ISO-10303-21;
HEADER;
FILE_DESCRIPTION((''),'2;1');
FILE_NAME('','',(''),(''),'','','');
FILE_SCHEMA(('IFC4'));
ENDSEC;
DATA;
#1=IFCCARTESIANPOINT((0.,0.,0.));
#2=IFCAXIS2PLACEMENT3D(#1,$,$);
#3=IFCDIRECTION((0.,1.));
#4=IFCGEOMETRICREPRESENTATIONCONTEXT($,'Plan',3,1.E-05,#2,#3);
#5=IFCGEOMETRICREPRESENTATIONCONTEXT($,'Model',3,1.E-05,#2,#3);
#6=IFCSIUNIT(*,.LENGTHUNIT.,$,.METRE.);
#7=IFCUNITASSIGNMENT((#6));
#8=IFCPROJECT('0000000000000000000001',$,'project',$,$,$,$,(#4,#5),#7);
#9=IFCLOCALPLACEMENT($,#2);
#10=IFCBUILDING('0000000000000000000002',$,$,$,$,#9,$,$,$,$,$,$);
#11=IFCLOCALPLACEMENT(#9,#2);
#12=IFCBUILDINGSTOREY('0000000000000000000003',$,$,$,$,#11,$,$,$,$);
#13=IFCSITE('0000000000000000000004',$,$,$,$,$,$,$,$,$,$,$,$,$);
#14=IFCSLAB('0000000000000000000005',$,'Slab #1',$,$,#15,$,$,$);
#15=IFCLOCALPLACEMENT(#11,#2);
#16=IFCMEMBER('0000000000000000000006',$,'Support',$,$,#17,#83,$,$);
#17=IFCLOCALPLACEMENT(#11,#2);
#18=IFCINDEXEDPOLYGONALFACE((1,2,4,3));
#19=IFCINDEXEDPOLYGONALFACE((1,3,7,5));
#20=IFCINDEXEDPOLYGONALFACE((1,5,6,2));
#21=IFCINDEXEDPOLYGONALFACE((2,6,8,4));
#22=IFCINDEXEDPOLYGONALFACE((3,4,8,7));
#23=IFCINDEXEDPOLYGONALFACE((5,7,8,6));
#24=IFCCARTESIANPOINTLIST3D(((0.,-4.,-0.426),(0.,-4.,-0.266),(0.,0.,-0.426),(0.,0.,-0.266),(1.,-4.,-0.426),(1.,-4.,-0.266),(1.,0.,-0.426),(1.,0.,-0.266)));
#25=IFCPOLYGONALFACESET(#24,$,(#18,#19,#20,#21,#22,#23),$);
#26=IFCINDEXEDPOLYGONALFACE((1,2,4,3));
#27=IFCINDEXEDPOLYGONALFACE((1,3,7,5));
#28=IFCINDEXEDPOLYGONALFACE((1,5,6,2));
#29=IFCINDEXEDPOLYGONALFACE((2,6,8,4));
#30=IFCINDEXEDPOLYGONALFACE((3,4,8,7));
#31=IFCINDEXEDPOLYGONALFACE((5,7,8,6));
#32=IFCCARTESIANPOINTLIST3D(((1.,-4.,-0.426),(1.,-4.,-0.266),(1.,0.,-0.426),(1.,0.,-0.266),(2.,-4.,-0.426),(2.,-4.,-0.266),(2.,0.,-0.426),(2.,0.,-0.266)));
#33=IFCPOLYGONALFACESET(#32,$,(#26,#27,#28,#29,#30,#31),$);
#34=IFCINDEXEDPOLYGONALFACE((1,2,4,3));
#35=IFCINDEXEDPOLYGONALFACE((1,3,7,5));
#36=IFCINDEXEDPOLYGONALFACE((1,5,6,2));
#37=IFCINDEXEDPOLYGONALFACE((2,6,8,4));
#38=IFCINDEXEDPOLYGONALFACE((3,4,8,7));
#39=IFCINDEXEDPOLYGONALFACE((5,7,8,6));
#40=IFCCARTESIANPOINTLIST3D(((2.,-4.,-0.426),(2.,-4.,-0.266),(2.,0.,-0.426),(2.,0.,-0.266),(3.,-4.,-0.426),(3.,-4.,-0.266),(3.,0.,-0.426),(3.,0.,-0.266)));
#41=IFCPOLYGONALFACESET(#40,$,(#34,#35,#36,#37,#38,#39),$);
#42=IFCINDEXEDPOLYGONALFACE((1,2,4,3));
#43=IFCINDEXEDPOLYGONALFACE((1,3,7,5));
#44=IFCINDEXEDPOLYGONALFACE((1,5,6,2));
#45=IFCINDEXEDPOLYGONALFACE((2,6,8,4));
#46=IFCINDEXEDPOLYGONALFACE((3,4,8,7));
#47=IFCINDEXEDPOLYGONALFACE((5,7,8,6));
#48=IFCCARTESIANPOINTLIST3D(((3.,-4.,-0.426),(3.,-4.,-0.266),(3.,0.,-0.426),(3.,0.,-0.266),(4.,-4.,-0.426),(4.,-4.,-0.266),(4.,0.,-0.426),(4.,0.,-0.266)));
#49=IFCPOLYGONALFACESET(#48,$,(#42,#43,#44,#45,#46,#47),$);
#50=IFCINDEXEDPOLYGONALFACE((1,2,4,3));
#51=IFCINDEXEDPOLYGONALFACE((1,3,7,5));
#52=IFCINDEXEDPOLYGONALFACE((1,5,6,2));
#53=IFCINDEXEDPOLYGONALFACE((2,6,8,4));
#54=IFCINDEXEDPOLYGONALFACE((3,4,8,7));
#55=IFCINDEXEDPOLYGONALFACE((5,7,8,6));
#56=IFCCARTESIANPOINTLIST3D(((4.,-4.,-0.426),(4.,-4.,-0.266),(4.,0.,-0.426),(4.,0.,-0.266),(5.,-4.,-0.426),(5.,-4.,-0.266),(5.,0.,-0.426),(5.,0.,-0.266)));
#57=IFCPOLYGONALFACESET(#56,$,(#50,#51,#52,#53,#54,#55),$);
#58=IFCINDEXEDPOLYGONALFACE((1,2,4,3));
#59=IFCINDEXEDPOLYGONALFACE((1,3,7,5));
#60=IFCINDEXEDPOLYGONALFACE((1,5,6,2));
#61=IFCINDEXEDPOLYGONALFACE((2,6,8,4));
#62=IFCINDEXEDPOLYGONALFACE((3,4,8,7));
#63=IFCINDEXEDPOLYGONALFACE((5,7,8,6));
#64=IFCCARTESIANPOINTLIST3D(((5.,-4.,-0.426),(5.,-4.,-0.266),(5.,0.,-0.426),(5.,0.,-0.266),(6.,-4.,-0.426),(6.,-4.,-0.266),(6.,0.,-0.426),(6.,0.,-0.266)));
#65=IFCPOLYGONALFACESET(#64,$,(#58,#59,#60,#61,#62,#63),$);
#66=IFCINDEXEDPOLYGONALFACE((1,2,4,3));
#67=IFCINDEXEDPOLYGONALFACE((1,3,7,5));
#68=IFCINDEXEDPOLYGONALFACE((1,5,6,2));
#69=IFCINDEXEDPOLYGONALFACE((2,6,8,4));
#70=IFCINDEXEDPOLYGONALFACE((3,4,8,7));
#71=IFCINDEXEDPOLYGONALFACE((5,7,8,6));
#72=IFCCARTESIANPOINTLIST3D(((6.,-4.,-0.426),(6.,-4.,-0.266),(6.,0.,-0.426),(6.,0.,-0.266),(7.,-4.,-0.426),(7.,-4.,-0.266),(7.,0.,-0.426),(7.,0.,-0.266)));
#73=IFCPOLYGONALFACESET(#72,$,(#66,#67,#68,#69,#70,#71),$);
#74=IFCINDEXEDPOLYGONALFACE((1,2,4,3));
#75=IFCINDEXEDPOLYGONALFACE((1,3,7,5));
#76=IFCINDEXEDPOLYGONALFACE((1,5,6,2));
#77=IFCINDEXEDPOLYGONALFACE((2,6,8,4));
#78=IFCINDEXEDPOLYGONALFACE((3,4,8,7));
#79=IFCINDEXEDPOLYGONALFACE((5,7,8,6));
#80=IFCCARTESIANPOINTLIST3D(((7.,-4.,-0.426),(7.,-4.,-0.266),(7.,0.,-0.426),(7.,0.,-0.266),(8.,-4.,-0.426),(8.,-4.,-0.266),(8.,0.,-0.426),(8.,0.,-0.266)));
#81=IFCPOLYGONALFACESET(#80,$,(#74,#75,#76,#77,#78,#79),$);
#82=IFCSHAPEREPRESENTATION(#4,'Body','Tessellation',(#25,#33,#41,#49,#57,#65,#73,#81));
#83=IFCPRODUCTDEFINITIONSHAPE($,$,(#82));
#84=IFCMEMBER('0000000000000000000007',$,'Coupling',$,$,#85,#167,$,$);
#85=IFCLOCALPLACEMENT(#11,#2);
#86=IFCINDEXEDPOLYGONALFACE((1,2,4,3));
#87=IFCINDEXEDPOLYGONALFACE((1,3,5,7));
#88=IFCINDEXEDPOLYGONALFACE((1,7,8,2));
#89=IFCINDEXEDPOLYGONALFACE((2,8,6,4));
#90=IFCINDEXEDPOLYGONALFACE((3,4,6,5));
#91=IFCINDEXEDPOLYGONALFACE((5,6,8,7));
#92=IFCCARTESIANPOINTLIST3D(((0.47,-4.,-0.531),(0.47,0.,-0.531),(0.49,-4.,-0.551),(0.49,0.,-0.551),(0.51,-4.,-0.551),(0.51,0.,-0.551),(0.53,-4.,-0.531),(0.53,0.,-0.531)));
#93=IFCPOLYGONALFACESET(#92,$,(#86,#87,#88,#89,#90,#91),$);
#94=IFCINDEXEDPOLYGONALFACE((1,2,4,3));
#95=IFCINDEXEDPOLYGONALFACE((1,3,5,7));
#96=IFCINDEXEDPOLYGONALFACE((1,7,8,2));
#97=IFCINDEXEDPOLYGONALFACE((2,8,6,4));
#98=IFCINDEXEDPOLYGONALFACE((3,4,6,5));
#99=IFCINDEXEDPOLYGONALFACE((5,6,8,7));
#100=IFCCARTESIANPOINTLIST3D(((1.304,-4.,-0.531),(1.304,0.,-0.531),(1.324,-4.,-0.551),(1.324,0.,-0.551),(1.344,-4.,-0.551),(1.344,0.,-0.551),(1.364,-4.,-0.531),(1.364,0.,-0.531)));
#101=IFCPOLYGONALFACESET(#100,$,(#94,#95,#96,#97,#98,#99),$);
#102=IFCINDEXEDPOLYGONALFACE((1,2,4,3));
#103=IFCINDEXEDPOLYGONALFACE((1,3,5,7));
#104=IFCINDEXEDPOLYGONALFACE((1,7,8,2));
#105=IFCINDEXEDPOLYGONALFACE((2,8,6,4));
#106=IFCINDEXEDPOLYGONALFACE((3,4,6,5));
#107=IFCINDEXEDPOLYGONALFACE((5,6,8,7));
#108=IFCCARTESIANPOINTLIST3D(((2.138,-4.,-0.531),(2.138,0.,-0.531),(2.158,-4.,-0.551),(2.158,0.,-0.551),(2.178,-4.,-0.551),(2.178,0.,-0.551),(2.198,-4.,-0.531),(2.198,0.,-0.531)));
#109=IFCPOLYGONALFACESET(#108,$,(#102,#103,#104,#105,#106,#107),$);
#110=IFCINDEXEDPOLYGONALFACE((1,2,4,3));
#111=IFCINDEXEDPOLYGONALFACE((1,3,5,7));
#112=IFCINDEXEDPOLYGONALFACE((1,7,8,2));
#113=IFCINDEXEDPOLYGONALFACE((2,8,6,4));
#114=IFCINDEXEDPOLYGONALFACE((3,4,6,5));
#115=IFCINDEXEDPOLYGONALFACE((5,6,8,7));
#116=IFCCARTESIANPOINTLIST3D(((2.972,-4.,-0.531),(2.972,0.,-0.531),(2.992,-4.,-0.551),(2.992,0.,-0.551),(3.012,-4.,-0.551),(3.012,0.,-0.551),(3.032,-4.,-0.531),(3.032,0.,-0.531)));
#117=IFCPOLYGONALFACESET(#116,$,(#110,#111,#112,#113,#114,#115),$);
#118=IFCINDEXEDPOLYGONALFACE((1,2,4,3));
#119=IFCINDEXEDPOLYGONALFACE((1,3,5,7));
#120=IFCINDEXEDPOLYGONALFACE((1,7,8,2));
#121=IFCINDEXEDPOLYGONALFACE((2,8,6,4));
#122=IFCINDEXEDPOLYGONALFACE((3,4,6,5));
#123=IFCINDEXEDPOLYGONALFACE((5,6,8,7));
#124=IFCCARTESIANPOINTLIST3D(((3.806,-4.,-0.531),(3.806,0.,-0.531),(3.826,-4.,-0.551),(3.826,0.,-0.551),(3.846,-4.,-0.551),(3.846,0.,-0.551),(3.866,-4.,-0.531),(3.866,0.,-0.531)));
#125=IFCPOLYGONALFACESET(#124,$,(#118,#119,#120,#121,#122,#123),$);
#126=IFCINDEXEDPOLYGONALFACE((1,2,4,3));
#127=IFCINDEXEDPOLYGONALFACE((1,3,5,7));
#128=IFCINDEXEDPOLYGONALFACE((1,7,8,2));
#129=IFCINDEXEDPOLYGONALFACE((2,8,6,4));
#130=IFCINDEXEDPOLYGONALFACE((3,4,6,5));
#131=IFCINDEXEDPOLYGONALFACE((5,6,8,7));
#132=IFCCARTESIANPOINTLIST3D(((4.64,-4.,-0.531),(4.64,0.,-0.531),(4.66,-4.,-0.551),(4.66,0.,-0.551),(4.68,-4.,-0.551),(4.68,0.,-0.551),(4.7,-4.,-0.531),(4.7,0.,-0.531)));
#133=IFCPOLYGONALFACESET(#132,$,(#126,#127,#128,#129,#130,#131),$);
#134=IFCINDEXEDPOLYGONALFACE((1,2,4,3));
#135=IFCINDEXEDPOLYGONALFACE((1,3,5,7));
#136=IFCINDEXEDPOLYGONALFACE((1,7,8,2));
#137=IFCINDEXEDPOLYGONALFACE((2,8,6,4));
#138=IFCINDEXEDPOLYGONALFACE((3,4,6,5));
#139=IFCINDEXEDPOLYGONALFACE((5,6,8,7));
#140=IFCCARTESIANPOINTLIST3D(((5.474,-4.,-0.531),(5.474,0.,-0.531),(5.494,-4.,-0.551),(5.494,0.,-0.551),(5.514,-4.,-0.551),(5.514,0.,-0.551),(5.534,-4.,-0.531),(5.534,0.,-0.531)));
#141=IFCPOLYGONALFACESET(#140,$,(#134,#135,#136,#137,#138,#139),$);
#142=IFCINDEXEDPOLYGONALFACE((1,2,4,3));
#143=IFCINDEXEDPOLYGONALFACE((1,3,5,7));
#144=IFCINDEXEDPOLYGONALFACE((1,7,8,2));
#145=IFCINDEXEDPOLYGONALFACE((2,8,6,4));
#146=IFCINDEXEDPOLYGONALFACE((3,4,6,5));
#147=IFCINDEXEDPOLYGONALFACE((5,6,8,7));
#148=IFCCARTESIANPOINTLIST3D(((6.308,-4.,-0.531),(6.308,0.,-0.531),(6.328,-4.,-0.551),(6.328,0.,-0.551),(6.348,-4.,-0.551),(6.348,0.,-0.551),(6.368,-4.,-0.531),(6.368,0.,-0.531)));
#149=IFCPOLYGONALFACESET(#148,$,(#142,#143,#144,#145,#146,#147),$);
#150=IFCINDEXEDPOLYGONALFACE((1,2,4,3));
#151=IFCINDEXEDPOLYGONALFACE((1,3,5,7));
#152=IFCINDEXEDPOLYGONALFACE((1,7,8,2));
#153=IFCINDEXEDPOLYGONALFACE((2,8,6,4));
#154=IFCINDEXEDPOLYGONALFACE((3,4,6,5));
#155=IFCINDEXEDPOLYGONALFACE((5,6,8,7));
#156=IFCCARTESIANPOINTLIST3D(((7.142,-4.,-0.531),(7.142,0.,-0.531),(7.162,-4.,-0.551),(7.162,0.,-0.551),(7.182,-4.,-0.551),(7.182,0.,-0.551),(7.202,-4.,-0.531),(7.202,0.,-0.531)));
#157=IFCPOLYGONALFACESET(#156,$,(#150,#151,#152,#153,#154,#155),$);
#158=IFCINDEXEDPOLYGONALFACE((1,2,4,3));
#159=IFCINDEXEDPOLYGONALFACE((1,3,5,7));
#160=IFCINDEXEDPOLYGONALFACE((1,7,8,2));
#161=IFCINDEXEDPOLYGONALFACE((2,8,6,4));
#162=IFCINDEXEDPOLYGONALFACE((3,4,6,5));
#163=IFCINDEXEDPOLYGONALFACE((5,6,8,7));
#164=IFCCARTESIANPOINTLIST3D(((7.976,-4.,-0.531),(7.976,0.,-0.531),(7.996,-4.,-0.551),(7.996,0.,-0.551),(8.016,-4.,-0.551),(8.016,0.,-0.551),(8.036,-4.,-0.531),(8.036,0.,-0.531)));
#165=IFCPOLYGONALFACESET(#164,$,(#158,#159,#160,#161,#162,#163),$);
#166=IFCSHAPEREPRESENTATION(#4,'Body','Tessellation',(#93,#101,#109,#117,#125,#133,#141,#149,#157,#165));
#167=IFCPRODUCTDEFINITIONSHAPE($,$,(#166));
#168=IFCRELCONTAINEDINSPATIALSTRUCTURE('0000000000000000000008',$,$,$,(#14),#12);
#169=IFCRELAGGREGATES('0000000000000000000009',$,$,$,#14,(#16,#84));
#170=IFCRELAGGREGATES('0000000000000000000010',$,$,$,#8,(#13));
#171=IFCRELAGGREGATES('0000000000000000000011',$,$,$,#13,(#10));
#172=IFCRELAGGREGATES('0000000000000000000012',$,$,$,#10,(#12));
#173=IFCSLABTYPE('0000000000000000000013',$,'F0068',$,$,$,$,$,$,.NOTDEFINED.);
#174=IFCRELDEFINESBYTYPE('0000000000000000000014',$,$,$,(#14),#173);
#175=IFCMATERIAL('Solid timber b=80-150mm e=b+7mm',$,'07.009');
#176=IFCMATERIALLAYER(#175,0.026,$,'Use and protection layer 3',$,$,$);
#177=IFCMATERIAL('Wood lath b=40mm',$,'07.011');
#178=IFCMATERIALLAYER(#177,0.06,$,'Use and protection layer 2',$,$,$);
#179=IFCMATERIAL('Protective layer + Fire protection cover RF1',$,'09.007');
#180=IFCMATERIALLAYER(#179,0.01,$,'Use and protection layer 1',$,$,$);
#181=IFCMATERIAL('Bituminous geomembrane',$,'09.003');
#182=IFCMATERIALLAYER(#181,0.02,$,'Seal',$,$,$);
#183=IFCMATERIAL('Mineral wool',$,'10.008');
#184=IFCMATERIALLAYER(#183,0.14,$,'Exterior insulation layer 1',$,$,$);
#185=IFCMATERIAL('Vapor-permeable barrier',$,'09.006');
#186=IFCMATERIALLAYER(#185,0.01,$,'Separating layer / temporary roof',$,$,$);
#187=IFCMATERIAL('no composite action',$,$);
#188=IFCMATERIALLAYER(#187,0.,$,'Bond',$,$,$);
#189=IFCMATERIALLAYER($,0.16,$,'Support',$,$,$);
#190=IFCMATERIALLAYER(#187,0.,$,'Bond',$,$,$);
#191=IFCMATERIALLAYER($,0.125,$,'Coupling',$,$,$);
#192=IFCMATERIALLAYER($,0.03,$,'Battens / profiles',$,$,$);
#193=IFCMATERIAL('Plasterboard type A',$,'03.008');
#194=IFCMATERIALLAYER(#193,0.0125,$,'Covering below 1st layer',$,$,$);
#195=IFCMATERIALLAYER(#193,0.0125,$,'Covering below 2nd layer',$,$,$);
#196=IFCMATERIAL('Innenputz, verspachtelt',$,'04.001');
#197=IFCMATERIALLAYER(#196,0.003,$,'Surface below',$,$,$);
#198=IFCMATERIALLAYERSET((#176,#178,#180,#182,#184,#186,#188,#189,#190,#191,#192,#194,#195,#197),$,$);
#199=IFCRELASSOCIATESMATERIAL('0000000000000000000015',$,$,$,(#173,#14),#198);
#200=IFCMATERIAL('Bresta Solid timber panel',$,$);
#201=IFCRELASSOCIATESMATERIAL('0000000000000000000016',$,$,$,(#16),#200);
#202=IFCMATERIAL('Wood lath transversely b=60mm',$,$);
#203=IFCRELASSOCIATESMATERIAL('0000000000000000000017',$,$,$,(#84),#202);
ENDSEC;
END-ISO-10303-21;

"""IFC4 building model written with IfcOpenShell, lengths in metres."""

from ifc_helpers import new_model, si_unit, direction, frame, frame_2d, origin, place, context, project, spatial, polyline, rectangle, outline, extrude, material, layer, layer_set, type_object, element, aggregate, save


model = new_model("IFC4")

# Units and contexts
plan_context = context("Plan", 3, precision=1e-05, world=origin(), true_north=direction((0.0, 1.0)))
model_context = context("Model", 3, precision=1e-05, world=origin(), true_north=direction((0.0, 1.0)))
ifc_project = project(units=[si_unit("LENGTHUNIT", "METRE")], contexts=[plan_context, model_context])

# Site, building, storey
site = spatial("IfcSite", under=ifc_project)
building_placement = place(None, origin())
building = spatial("IfcBuilding", under=site, at=building_placement)
storey_placement = place(building_placement, origin())
storey = spatial("IfcBuildingStorey", under=building, at=storey_placement)

# Slab, members
ifc_material_1 = material(Name="Solid timber b=80-150mm e=b+7mm", Category="07.009")
ifc_layer_1 = layer(ifc_material_1, 0.026, Name="Use and protection layer 3")
ifc_material_2 = material(Name="Wood lath b=40mm", Category="07.011")
ifc_layer_2 = layer(ifc_material_2, 0.06, Name="Use and protection layer 2")
ifc_material_3 = material(Name="Protective layer + Fire protection cover RF1", Category="09.007")
ifc_layer_3 = layer(ifc_material_3, 0.01, Name="Use and protection layer 1")
ifc_material_4 = material(Name="Bituminous geomembrane", Category="09.003")
ifc_layer_4 = layer(ifc_material_4, 0.02, Name="Seal")
ifc_material_5 = material(Name="Mineral wool", Category="10.008")
ifc_layer_5 = layer(ifc_material_5, 0.14, Name="Exterior insulation layer 1")
ifc_material_6 = material(Name="Vapor-permeable barrier", Category="09.006")
ifc_layer_6 = layer(ifc_material_6, 0.01, Name="Separating layer / temporary roof")
ifc_material_7 = material(Name="no composite action")
ifc_layer_7 = layer(ifc_material_7, 0.0, Name="Bond")
ifc_layer_8 = layer(None, 0.16, Name="Support")
ifc_layer_9 = layer(ifc_material_7, 0.0, Name="Bond")
ifc_layer_10 = layer(None, 0.125, Name="Coupling")
ifc_layer_11 = layer(None, 0.03, Name="Battens / profiles")
ifc_material_8 = material(Name="Plasterboard type A", Category="03.008")
ifc_layer_12 = layer(ifc_material_8, 0.0125, Name="Covering below 1st layer")
ifc_layer_13 = layer(ifc_material_8, 0.0125, Name="Covering below 2nd layer")
ifc_material_9 = material(Name="Innenputz, verspachtelt", Category="04.001")
ifc_layer_14 = layer(ifc_material_9, 0.003, Name="Surface below")
ifc_layer_set = layer_set([ifc_layer_1, ifc_layer_2, ifc_layer_3, ifc_layer_4, ifc_layer_5, ifc_layer_6, ifc_layer_7, ifc_layer_8, ifc_layer_9, ifc_layer_10, ifc_layer_11, ifc_layer_12, ifc_layer_13, ifc_layer_14])
slab_type = type_object("IfcSlabType", Name="F0068", PredefinedType="NOTDEFINED", material=ifc_layer_set)
slab_placement = place(None, frame((0.0, 0.0, 0.0), z_axis=(0.0, 0.0, -1.0), x_axis=(1.0, 0.0, 0.0)))
slab = element("IfcSlab", 1, at=slab_placement, inside=storey, type_object=slab_type, material=ifc_layer_set, Name="Slab #1")
ifc_material_10 = material(Name="Bresta Solid timber panel")
member_1_placement = place(slab_placement, origin())
member_1 = element("IfcMember", 2, at=member_1_placement, material=ifc_material_10, Name="Support", context=plan_context, shape_type="SweptSolid", body=[
    extrude(rectangle(XDim=1.0, YDim=0.16, at=frame_2d((0.5, 0.08), x_axis=(1.0, 0.0))), frame((0.0, 4.0, 0.266), z_axis=(0.0, -1.0, 0.0), x_axis=(1.0, 0.0, 0.0)), (0.0, 0.0, 1.0), 4.0),
    extrude(rectangle(XDim=1.0, YDim=0.16, at=frame_2d((0.5, 0.08), x_axis=(1.0, 0.0))), frame((1.0, 4.0, 0.266), z_axis=(0.0, -1.0, 0.0), x_axis=(1.0, 0.0, 0.0)), (0.0, 0.0, 1.0), 4.0),
    extrude(rectangle(XDim=1.0, YDim=0.16, at=frame_2d((0.5, 0.08), x_axis=(1.0, 0.0))), frame((2.0, 4.0, 0.266), z_axis=(0.0, -1.0, 0.0), x_axis=(1.0, 0.0, 0.0)), (0.0, 0.0, 1.0), 4.0),
    extrude(rectangle(XDim=1.0, YDim=0.16, at=frame_2d((0.5, 0.08), x_axis=(1.0, 0.0))), frame((3.0, 4.0, 0.266), z_axis=(0.0, -1.0, 0.0), x_axis=(1.0, 0.0, 0.0)), (0.0, 0.0, 1.0), 4.0),
    extrude(rectangle(XDim=1.0, YDim=0.16, at=frame_2d((0.5, 0.08), x_axis=(1.0, 0.0))), frame((4.0, 4.0, 0.266), z_axis=(0.0, -1.0, 0.0), x_axis=(1.0, 0.0, 0.0)), (0.0, 0.0, 1.0), 4.0),
    extrude(rectangle(XDim=1.0, YDim=0.16, at=frame_2d((0.5, 0.08), x_axis=(1.0, 0.0))), frame((5.0, 4.0, 0.266), z_axis=(0.0, -1.0, 0.0), x_axis=(1.0, 0.0, 0.0)), (0.0, 0.0, 1.0), 4.0),
    extrude(rectangle(XDim=1.0, YDim=0.16, at=frame_2d((0.5, 0.08), x_axis=(1.0, 0.0))), frame((6.0, 4.0, 0.266), z_axis=(0.0, -1.0, 0.0), x_axis=(1.0, 0.0, 0.0)), (0.0, 0.0, 1.0), 4.0),
    extrude(rectangle(XDim=1.0, YDim=0.16, at=frame_2d((0.5, 0.08), x_axis=(1.0, 0.0))), frame((7.0, 4.0, 0.266), z_axis=(0.0, -1.0, 0.0), x_axis=(1.0, 0.0, 0.0)), (0.0, 0.0, 1.0), 4.0),
])
ifc_material_11 = material(Name="Wood lath transversely b=60mm")
member_2_placement = place(slab_placement, origin())
member_2 = element("IfcMember", 3, at=member_2_placement, material=ifc_material_11, Name="Coupling", context=plan_context, shape_type="SweptSolid", body=[
    extrude(outline(polyline([(0.0, 0.0), (0.06, 0.0), (0.04, 0.02), (0.02, 0.02), (0.0, 0.0)])), frame((0.47, 4.0, 0.531), z_axis=(0.0, -1.0, 0.0), x_axis=(1.0, 0.0, 0.0)), (0.0, 0.0, 1.0), 4.0),
    extrude(outline(polyline([(0.0, 0.0), (0.06, 0.0), (0.04, 0.02), (0.02, 0.02), (0.0, 0.0)])), frame((1.304, 4.0, 0.531), z_axis=(0.0, -1.0, 0.0), x_axis=(1.0, 0.0, 0.0)), (0.0, 0.0, 1.0), 4.0),
    extrude(outline(polyline([(0.0, 0.0), (0.06, 0.0), (0.04, 0.02), (0.02, 0.02), (0.0, 0.0)])), frame((2.138, 4.0, 0.531), z_axis=(0.0, -1.0, 0.0), x_axis=(1.0, 0.0, 0.0)), (0.0, 0.0, 1.0), 4.0),
    extrude(outline(polyline([(0.0, 0.0), (0.06, 0.0), (0.04, 0.02), (0.02, 0.02), (0.0, 0.0)])), frame((2.972, 4.0, 0.531), z_axis=(0.0, -1.0, 0.0), x_axis=(1.0, 0.0, 0.0)), (0.0, 0.0, 1.0), 4.0),
    extrude(outline(polyline([(0.0, 0.0), (0.06, 0.0), (0.04, 0.02), (0.02, 0.02), (0.0, 0.0)])), frame((3.806, 4.0, 0.531), z_axis=(0.0, -1.0, 0.0), x_axis=(1.0, 0.0, 0.0)), (0.0, 0.0, 1.0), 4.0),
    extrude(outline(polyline([(0.0, 0.0), (0.06, 0.0), (0.04, 0.02), (0.02, 0.02), (0.0, 0.0)])), frame((4.64, 4.0, 0.531), z_axis=(0.0, -1.0, 0.0), x_axis=(1.0, 0.0, 0.0)), (0.0, 0.0, 1.0), 4.0),
    extrude(outline(polyline([(0.0, 0.0), (0.06, 0.0), (0.04, 0.02), (0.02, 0.02), (0.0, 0.0)])), frame((5.474, 4.0, 0.531), z_axis=(0.0, -1.0, 0.0), x_axis=(1.0, 0.0, 0.0)), (0.0, 0.0, 1.0), 4.0),
    extrude(outline(polyline([(0.0, 0.0), (0.06, 0.0), (0.04, 0.02), (0.02, 0.02), (0.0, 0.0)])), frame((6.308, 4.0, 0.531), z_axis=(0.0, -1.0, 0.0), x_axis=(1.0, 0.0, 0.0)), (0.0, 0.0, 1.0), 4.0),
    extrude(outline(polyline([(0.0, 0.0), (0.06, 0.0), (0.04, 0.02), (0.02, 0.02), (0.0, 0.0)])), frame((7.142, 4.0, 0.531), z_axis=(0.0, -1.0, 0.0), x_axis=(1.0, 0.0, 0.0)), (0.0, 0.0, 1.0), 4.0),
    extrude(outline(polyline([(0.0, 0.0), (0.06, 0.0), (0.04, 0.02), (0.02, 0.02), (0.0, 0.0)])), frame((7.976, 4.0, 0.531), z_axis=(0.0, -1.0, 0.0), x_axis=(1.0, 0.0, 0.0)), (0.0, 0.0, 1.0), 4.0),
])
aggregate(slab, [member_1, member_2])

save(model, "model.ifc")
